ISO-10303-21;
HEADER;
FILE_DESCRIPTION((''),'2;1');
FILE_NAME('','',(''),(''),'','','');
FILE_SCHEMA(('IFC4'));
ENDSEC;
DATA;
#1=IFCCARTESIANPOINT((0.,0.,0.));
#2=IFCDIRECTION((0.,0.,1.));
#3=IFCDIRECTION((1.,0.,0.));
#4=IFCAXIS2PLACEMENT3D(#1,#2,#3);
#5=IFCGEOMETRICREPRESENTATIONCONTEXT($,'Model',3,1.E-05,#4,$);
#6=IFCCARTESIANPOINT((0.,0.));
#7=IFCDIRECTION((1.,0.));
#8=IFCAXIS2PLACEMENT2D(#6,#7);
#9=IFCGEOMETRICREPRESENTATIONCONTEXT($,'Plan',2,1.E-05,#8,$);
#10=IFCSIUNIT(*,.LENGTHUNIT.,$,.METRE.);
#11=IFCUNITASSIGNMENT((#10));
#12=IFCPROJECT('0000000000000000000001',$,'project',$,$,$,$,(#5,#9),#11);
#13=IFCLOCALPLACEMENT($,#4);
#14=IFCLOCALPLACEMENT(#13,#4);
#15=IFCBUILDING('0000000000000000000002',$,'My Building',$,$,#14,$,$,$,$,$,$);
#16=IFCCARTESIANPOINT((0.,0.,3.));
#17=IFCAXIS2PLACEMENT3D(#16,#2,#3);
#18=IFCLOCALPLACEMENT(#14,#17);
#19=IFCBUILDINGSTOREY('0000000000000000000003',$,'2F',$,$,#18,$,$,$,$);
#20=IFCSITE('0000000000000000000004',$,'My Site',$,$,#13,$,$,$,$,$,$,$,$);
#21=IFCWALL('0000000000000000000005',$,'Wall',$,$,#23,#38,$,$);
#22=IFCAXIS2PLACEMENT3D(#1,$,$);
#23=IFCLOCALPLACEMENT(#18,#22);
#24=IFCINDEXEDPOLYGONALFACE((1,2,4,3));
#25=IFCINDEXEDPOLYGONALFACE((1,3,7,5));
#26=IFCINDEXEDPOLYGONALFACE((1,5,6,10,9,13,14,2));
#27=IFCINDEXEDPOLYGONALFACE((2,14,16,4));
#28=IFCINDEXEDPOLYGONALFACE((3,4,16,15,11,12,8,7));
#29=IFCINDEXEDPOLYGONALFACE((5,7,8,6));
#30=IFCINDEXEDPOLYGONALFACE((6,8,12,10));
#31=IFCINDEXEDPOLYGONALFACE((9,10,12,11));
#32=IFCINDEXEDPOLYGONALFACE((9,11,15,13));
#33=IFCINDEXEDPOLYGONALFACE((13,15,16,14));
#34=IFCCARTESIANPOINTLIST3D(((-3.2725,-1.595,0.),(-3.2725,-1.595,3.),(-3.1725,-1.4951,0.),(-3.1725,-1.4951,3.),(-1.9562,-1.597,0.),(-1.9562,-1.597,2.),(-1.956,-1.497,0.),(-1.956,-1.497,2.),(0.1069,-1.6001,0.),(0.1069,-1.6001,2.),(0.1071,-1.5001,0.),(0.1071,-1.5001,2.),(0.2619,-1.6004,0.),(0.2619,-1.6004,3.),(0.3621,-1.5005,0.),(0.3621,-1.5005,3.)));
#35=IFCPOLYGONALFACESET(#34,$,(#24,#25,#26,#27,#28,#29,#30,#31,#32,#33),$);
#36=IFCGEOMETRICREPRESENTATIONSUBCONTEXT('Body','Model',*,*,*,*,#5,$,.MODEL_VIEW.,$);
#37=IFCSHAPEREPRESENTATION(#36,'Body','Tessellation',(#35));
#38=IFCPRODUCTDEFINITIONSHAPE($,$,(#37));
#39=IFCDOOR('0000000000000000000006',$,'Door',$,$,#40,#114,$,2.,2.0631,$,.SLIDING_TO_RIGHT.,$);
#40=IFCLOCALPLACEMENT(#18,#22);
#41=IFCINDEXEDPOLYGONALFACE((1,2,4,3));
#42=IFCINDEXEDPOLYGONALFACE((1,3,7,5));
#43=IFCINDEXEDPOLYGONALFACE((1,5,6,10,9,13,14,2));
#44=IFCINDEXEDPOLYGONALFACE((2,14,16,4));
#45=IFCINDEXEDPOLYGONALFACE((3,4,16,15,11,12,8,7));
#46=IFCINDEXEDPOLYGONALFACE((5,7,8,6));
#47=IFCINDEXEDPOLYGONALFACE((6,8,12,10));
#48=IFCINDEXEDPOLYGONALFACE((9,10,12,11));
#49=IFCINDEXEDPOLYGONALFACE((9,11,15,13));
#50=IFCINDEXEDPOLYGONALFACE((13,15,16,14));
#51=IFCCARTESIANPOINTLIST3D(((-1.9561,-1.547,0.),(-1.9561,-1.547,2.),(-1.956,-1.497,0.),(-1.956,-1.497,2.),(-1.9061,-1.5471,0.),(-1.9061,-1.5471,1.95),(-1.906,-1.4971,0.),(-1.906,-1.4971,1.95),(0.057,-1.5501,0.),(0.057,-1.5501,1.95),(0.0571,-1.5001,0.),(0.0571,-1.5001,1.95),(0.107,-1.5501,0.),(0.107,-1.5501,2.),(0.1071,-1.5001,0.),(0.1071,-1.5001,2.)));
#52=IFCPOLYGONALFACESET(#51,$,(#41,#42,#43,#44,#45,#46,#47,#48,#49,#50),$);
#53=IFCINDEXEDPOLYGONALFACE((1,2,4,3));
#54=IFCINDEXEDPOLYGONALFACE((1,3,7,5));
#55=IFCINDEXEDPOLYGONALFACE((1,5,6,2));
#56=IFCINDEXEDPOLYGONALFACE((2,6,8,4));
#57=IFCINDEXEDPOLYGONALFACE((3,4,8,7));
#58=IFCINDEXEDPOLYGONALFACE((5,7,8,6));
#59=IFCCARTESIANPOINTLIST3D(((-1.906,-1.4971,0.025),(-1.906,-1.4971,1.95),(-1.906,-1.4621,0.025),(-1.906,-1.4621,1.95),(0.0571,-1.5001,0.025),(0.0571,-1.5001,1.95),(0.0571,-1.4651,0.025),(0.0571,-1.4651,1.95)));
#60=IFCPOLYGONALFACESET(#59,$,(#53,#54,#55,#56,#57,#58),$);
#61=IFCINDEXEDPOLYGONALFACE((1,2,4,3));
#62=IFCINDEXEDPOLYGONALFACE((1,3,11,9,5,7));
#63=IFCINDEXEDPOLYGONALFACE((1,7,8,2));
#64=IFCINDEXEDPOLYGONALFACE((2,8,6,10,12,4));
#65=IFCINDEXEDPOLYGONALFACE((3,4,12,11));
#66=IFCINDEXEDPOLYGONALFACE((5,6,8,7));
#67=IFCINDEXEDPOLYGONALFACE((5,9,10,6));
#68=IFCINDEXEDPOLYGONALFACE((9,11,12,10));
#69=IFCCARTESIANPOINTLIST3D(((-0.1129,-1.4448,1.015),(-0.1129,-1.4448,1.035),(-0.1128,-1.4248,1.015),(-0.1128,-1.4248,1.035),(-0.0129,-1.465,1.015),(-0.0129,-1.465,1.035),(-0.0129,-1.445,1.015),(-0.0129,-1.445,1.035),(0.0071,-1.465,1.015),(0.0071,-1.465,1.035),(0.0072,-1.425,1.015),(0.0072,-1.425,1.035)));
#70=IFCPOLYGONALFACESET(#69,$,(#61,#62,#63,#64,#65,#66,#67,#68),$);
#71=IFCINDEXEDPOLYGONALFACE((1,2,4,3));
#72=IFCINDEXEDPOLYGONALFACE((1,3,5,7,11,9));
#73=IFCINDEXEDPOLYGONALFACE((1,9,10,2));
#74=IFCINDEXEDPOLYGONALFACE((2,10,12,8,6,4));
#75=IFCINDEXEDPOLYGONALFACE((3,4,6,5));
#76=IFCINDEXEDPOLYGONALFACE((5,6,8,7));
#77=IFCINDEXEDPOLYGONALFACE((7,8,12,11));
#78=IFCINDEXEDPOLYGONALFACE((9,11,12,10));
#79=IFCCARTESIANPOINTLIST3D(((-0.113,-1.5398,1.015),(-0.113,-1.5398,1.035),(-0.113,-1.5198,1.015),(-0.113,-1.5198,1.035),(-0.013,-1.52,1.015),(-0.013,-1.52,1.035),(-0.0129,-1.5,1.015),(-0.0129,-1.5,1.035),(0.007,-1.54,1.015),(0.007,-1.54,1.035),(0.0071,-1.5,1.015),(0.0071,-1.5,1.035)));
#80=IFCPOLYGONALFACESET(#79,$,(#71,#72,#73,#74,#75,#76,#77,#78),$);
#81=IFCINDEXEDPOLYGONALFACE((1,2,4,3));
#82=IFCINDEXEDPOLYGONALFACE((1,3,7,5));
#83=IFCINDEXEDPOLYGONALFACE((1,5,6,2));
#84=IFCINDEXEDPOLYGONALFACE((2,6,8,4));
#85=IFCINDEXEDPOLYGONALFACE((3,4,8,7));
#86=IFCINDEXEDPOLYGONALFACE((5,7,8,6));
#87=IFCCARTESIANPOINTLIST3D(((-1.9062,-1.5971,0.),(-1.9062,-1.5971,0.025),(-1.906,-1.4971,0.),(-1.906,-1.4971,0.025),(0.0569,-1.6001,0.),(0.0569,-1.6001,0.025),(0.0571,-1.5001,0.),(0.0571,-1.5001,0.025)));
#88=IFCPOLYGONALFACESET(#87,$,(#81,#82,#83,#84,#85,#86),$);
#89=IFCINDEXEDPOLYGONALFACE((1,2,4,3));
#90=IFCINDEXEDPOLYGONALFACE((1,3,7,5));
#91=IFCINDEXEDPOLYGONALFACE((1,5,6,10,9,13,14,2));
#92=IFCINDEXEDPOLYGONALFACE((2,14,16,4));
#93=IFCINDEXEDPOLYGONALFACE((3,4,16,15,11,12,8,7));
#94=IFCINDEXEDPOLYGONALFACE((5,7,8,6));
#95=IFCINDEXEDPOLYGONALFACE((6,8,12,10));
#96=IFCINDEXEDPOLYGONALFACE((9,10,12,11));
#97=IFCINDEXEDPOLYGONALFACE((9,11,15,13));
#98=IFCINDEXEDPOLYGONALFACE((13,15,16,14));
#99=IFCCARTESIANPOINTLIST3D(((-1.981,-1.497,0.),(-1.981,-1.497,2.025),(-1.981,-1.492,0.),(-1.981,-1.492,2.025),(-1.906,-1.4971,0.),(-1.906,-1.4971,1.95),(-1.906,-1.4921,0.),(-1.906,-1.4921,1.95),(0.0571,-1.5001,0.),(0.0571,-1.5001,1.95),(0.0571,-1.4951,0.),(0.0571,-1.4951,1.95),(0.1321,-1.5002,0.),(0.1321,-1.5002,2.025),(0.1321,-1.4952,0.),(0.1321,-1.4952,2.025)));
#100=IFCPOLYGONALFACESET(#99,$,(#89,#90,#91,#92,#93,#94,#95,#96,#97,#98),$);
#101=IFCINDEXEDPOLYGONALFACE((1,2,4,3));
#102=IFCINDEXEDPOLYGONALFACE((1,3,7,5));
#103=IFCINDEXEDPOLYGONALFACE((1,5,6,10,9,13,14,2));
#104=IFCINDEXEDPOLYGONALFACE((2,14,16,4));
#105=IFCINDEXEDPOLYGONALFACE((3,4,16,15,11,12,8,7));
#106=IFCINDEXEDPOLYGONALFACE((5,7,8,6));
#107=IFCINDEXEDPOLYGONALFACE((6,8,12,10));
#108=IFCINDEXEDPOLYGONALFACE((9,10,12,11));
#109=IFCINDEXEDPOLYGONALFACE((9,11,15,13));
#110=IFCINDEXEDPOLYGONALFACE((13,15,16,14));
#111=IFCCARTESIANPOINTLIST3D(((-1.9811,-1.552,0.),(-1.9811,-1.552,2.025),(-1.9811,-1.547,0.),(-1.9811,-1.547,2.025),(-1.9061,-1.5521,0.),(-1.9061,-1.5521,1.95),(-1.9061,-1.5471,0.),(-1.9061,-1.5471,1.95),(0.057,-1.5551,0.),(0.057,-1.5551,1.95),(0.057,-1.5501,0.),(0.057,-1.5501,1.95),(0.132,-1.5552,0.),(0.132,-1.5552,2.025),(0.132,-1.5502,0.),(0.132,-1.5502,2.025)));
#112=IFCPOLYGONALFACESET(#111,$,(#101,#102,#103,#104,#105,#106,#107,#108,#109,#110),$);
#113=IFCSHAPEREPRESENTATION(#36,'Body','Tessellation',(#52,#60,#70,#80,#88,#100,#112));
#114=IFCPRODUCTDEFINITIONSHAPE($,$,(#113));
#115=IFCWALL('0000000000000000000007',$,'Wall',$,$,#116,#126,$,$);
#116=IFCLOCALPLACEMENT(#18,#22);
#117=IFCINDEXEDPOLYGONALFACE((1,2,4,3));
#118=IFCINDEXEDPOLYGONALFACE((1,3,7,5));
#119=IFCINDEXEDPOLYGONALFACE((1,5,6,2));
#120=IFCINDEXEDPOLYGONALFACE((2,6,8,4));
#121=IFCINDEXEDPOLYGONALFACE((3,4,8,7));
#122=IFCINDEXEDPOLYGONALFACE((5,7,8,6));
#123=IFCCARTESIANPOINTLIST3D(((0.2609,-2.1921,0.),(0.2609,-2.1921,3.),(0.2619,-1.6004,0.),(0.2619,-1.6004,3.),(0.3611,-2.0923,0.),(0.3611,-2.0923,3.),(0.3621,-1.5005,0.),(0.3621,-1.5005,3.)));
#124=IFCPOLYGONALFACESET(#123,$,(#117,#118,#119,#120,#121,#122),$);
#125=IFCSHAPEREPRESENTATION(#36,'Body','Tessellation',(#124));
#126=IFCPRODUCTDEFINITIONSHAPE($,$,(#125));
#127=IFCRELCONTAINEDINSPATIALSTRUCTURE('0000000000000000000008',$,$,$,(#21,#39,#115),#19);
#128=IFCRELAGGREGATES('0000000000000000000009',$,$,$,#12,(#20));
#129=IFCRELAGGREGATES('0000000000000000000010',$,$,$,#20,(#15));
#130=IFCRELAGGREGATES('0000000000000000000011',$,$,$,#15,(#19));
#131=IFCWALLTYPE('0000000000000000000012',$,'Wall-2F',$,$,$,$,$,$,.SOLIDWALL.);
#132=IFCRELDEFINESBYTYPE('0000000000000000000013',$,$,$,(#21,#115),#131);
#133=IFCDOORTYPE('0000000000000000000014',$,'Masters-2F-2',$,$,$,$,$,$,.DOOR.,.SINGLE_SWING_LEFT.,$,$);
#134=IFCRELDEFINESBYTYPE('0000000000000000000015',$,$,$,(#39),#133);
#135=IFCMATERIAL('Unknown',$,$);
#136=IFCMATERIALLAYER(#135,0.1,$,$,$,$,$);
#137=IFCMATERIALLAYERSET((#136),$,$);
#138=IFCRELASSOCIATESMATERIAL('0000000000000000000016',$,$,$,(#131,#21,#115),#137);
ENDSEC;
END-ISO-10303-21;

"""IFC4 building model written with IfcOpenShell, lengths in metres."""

from ifc_helpers import new_model, entity, si_unit, frame, origin_with_axes, origin_2d_with_axis, place, context, subcontext, project, spatial, line, indexed_curve, outline, extrude, shape, source, transform, mapped, material, layer, layer_set, layer_usage, type_object, type_shapes, element, fill, save


model = new_model("IFC4")

# Units and contexts
model_context = context("Model", 3, precision=1e-05, world=origin_with_axes())
plan_context = context("Plan", 2, precision=1e-05, world=origin_2d_with_axis())
body_context_1 = subcontext(model_context, "Body", "Model", "MODEL_VIEW")
body_context_2 = subcontext(plan_context, "Body", "Plan", "PLAN_VIEW")
ifc_project = project(units=[si_unit("LENGTHUNIT", "METRE")], contexts=[model_context, plan_context])

# Site, building, storey
site_placement = place(None, origin_with_axes())
site = spatial("IfcSite", under=ifc_project, at=site_placement, Name="My Site")
building_placement = place(site_placement, origin_with_axes())
building = spatial("IfcBuilding", under=site, at=building_placement, Name="My Building")
storey_placement = place(building_placement, frame((0.0, 0.0, 3.0), z_axis=(0.0, 0.0, 1.0), x_axis=(1.0, 0.0, 0.0)))
storey = spatial("IfcBuildingStorey", under=building, at=storey_placement, Name="2F")

# Shared definitions
ifc_material = material(Name="Unknown")

# Shared definitions
ifc_layer_1 = layer(ifc_material, 0.1)
ifc_layer_set_1 = layer_set([ifc_layer_1])
wall_type = type_object("IfcWallType", Name="Wall-2F", PredefinedType="SOLIDWALL", material=ifc_layer_set_1)

# Wall, opening, door
ifc_layer_usage_1 = layer_usage(ifc_layer_set_1, "AXIS2", "POSITIVE", 0.0)
wall_1_placement = place(storey_placement, frame((-3.2725, -1.595, 0.0), z_axis=(0.0, 0.0, 1.0), x_axis=(0.999999, -0.001525, 0.0)))
wall_1 = element("IfcWall", 1, at=wall_1_placement, inside=storey, type_object=wall_type, material=ifc_layer_usage_1, Name="Wall", context=body_context_1, shape_type="SweptSolid", body=[
    extrude(outline(indexed_curve([(0.0, 0.0), (0.0998, 0.1), (3.6345, 0.1), (3.5345, 0.0)], segments=[line(1, 2, 3, 4, 1)])), origin_with_axes(), (0.0, 0.0, 1.0), 3.0),
])
shared_shape_1 = source(origin_with_axes(), body_context_1, "Body", "SweptSolid", [
    extrude(outline(indexed_curve([(0.0, 0.0), (2.0631, 0.0), (2.0631, 2.0), (0.0, 2.0)], segments=[line(1, 2, 3, 4, 1)])), frame((0.0, -0.6, 0.0), z_axis=(0.0, -1.0, 0.0), x_axis=(1.0, 0.0, 0.0)), (0.0, 0.0, -1.0), 1.2),
])
opening_1_placement = place(wall_1_placement, frame((3.3794, 0.1, 0.0), z_axis=(0.0, 0.0, 1.0), x_axis=(-1.0, 0.0, 0.0)))
opening_1 = element("IfcOpeningElement", 2, at=opening_1_placement, cuts=wall_1, PredefinedType="OPENING", context=body_context_1, shape_type="MappedRepresentation", body=[
    mapped(shared_shape_1, transform((0.0, 0.0, 0.0), x_axis=(1.0, 0.0, 0.0), y_axis=(0.0, 1.0, 0.0), z_axis=(0.0, 0.0, 1.0), scale=1.0)),
])
door_type_1 = type_object("IfcDoorType", Name="Masters-2F-2", OperationType="SINGLE_SWING_LEFT", PredefinedType="DOOR")
shared_shape_2 = source(origin_with_axes(), body_context_1, "Body", "SweptSolid", [
    extrude(outline(indexed_curve([(0.0, 0.0), (0.0, 2.0), (2.0631, 2.0), (2.0631, 0.0), (2.0131, 0.0), (2.0131, 1.95), (0.05, 1.95), (0.05, 0.0)], segments=[line(1, 2, 3, 4, 5, 6, 7, 8, 1)])), frame((0.0, 0.0, 0.0), z_axis=(0.0, -1.0, 0.0), x_axis=(1.0, 0.0, 0.0)), (0.0, 0.0, -1.0), 0.05),
    extrude(outline(indexed_curve([(0.0, 0.0), (1.9631, 0.0), (1.9631, 0.035), (0.0, 0.035)], segments=[line(1, 2, 3, 4, 1)])), frame((0.05, -0.035, 0.025), z_axis=(0.0, 0.0, 1.0), x_axis=(1.0, 0.0, 0.0)), (0.0, 0.0, 1.0), 1.925),
    extrude(outline(indexed_curve([(0.0, 0.0), (0.0, -0.04), (0.12, -0.04), (0.12, -0.02), (0.02, -0.02), (0.02, 0.0)], segments=[line(1, 2, 3, 4, 5, 6, 1)])), frame((0.1, -0.035, 1.015), z_axis=(0.0, 0.0, 1.0), x_axis=(1.0, 0.0, 0.0)), (0.0, 0.0, 1.0), 0.02),
    extrude(outline(indexed_curve([(0.0, 0.0), (0.0, 0.04), (0.12, 0.04), (0.12, 0.02), (0.02, 0.02), (0.02, 0.0)], segments=[line(1, 2, 3, 4, 5, 6, 1)])), frame((0.1, 0.0, 1.015), z_axis=(0.0, 0.0, 1.0), x_axis=(1.0, 0.0, 0.0)), (0.0, 0.0, 1.0), 0.02),
    extrude(outline(indexed_curve([(0.0, 0.0), (1.9631, 0.0), (1.9631, 0.1), (0.0, 0.1)], segments=[line(1, 2, 3, 4, 1)])), frame((0.05, 0.0, 0.0), z_axis=(0.0, 0.0, 1.0), x_axis=(1.0, 0.0, 0.0)), (0.0, 0.0, 1.0), 0.025),
    extrude(outline(indexed_curve([(0.0, 0.0), (0.0, 2.025), (2.1131, 2.025), (2.1131, 0.0), (2.0381, 0.0), (2.0381, 1.95), (0.075, 1.95), (0.075, 0.0)], segments=[line(1, 2, 3, 4, 5, 6, 7, 8, 1)])), frame((-0.025, -0.005, 0.0), z_axis=(0.0, -1.0, 0.0), x_axis=(1.0, 0.0, 0.0)), (0.0, 0.0, -1.0), 0.005),
    extrude(outline(indexed_curve([(0.0, 0.0), (0.0, 2.025), (2.1131, 2.025), (2.1131, 0.0), (2.0381, 0.0), (2.0381, 1.95), (0.075, 1.95), (0.075, 0.0)], segments=[line(1, 2, 3, 4, 5, 6, 7, 8, 1)])), frame((-0.025, 0.05, 0.0), z_axis=(0.0, -1.0, 0.0), x_axis=(1.0, 0.0, 0.0)), (0.0, 0.0, -1.0), 0.005),
])
shared_shape_3 = source(origin_with_axes(), body_context_2, "Body", "Curve2D", [
    entity("IfcIndexedPolyCurve", entity("IfcCartesianPointList2D", [[0.0, 0.0], [0.05, 0.0], [0.05, 0.05], [0.0, 0.05]]), [entity("IfcLineIndex", [1, 2, 3, 4, 1])]),
    entity("IfcIndexedPolyCurve", entity("IfcCartesianPointList2D", [[2.0631, 0.0], [2.0131, 0.0], [2.0131, 0.05], [2.0631, 0.05]]), [entity("IfcLineIndex", [1, 2, 3, 4, 1])]),
    entity("IfcIndexedPolyCurve", entity("IfcCartesianPointList2D", [[2.9946, -0.035], [1.0315, -0.035], [1.0315, 0.0], [2.9946, 0.0]]), [entity("IfcLineIndex", [1, 2, 3, 4, 1])]),
])
type_shapes(door_type_1, [shared_shape_2, shared_shape_3])
door_1_placement = place(opening_1_placement, frame((0.0, 0.0, 0.0), z_axis=(0.0, 0.0, 1.0), x_axis=(1.0, 0.0, 0.0)))
door_1 = element("IfcDoor", 3, at=door_1_placement, inside=storey, type_object=door_type_1, Name="Door", OperationType="SLIDING_TO_RIGHT", OverallHeight=2.0, OverallWidth=2.0631, shapes=[
    shape(body_context_1, "Body", "MappedRepresentation", [mapped(shared_shape_2, transform((0.0, 0.0, 0.0), x_axis=(1.0, 0.0, 0.0), y_axis=(0.0, 1.0, 0.0), z_axis=(0.0, 0.0, 1.0), scale=1.0))]),
    shape(body_context_2, "Body", "MappedRepresentation", [mapped(shared_shape_3, transform((0.0, 0.0, 0.0), x_axis=(1.0, 0.0, 0.0), y_axis=(0.0, 1.0, 0.0), z_axis=(0.0, 0.0, 1.0), scale=1.0))]),
])
fill(opening_1, door_1)

# Wall
ifc_layer_usage_2 = layer_usage(ifc_layer_set_1, "AXIS2", "POSITIVE", 0.0)
wall_2_placement = place(storey_placement, frame((0.2619, -1.6004, 0.0), z_axis=(0.0, 0.0, 1.0), x_axis=(-0.001703, -0.999999, 0.0)))
element("IfcWall", 4, at=wall_2_placement, inside=storey, type_object=wall_type, material=ifc_layer_usage_2, Name="Wall", context=body_context_1, shape_type="SweptSolid", body=[
    extrude(outline(indexed_curve([(0.0, 0.0), (-0.1, 0.1), (0.4917, 0.1), (0.5917, 0.0)], segments=[line(1, 2, 3, 4, 1)])), origin_with_axes(), (0.0, 0.0, 1.0), 3.0),
])

save(model, "model.ifc")
